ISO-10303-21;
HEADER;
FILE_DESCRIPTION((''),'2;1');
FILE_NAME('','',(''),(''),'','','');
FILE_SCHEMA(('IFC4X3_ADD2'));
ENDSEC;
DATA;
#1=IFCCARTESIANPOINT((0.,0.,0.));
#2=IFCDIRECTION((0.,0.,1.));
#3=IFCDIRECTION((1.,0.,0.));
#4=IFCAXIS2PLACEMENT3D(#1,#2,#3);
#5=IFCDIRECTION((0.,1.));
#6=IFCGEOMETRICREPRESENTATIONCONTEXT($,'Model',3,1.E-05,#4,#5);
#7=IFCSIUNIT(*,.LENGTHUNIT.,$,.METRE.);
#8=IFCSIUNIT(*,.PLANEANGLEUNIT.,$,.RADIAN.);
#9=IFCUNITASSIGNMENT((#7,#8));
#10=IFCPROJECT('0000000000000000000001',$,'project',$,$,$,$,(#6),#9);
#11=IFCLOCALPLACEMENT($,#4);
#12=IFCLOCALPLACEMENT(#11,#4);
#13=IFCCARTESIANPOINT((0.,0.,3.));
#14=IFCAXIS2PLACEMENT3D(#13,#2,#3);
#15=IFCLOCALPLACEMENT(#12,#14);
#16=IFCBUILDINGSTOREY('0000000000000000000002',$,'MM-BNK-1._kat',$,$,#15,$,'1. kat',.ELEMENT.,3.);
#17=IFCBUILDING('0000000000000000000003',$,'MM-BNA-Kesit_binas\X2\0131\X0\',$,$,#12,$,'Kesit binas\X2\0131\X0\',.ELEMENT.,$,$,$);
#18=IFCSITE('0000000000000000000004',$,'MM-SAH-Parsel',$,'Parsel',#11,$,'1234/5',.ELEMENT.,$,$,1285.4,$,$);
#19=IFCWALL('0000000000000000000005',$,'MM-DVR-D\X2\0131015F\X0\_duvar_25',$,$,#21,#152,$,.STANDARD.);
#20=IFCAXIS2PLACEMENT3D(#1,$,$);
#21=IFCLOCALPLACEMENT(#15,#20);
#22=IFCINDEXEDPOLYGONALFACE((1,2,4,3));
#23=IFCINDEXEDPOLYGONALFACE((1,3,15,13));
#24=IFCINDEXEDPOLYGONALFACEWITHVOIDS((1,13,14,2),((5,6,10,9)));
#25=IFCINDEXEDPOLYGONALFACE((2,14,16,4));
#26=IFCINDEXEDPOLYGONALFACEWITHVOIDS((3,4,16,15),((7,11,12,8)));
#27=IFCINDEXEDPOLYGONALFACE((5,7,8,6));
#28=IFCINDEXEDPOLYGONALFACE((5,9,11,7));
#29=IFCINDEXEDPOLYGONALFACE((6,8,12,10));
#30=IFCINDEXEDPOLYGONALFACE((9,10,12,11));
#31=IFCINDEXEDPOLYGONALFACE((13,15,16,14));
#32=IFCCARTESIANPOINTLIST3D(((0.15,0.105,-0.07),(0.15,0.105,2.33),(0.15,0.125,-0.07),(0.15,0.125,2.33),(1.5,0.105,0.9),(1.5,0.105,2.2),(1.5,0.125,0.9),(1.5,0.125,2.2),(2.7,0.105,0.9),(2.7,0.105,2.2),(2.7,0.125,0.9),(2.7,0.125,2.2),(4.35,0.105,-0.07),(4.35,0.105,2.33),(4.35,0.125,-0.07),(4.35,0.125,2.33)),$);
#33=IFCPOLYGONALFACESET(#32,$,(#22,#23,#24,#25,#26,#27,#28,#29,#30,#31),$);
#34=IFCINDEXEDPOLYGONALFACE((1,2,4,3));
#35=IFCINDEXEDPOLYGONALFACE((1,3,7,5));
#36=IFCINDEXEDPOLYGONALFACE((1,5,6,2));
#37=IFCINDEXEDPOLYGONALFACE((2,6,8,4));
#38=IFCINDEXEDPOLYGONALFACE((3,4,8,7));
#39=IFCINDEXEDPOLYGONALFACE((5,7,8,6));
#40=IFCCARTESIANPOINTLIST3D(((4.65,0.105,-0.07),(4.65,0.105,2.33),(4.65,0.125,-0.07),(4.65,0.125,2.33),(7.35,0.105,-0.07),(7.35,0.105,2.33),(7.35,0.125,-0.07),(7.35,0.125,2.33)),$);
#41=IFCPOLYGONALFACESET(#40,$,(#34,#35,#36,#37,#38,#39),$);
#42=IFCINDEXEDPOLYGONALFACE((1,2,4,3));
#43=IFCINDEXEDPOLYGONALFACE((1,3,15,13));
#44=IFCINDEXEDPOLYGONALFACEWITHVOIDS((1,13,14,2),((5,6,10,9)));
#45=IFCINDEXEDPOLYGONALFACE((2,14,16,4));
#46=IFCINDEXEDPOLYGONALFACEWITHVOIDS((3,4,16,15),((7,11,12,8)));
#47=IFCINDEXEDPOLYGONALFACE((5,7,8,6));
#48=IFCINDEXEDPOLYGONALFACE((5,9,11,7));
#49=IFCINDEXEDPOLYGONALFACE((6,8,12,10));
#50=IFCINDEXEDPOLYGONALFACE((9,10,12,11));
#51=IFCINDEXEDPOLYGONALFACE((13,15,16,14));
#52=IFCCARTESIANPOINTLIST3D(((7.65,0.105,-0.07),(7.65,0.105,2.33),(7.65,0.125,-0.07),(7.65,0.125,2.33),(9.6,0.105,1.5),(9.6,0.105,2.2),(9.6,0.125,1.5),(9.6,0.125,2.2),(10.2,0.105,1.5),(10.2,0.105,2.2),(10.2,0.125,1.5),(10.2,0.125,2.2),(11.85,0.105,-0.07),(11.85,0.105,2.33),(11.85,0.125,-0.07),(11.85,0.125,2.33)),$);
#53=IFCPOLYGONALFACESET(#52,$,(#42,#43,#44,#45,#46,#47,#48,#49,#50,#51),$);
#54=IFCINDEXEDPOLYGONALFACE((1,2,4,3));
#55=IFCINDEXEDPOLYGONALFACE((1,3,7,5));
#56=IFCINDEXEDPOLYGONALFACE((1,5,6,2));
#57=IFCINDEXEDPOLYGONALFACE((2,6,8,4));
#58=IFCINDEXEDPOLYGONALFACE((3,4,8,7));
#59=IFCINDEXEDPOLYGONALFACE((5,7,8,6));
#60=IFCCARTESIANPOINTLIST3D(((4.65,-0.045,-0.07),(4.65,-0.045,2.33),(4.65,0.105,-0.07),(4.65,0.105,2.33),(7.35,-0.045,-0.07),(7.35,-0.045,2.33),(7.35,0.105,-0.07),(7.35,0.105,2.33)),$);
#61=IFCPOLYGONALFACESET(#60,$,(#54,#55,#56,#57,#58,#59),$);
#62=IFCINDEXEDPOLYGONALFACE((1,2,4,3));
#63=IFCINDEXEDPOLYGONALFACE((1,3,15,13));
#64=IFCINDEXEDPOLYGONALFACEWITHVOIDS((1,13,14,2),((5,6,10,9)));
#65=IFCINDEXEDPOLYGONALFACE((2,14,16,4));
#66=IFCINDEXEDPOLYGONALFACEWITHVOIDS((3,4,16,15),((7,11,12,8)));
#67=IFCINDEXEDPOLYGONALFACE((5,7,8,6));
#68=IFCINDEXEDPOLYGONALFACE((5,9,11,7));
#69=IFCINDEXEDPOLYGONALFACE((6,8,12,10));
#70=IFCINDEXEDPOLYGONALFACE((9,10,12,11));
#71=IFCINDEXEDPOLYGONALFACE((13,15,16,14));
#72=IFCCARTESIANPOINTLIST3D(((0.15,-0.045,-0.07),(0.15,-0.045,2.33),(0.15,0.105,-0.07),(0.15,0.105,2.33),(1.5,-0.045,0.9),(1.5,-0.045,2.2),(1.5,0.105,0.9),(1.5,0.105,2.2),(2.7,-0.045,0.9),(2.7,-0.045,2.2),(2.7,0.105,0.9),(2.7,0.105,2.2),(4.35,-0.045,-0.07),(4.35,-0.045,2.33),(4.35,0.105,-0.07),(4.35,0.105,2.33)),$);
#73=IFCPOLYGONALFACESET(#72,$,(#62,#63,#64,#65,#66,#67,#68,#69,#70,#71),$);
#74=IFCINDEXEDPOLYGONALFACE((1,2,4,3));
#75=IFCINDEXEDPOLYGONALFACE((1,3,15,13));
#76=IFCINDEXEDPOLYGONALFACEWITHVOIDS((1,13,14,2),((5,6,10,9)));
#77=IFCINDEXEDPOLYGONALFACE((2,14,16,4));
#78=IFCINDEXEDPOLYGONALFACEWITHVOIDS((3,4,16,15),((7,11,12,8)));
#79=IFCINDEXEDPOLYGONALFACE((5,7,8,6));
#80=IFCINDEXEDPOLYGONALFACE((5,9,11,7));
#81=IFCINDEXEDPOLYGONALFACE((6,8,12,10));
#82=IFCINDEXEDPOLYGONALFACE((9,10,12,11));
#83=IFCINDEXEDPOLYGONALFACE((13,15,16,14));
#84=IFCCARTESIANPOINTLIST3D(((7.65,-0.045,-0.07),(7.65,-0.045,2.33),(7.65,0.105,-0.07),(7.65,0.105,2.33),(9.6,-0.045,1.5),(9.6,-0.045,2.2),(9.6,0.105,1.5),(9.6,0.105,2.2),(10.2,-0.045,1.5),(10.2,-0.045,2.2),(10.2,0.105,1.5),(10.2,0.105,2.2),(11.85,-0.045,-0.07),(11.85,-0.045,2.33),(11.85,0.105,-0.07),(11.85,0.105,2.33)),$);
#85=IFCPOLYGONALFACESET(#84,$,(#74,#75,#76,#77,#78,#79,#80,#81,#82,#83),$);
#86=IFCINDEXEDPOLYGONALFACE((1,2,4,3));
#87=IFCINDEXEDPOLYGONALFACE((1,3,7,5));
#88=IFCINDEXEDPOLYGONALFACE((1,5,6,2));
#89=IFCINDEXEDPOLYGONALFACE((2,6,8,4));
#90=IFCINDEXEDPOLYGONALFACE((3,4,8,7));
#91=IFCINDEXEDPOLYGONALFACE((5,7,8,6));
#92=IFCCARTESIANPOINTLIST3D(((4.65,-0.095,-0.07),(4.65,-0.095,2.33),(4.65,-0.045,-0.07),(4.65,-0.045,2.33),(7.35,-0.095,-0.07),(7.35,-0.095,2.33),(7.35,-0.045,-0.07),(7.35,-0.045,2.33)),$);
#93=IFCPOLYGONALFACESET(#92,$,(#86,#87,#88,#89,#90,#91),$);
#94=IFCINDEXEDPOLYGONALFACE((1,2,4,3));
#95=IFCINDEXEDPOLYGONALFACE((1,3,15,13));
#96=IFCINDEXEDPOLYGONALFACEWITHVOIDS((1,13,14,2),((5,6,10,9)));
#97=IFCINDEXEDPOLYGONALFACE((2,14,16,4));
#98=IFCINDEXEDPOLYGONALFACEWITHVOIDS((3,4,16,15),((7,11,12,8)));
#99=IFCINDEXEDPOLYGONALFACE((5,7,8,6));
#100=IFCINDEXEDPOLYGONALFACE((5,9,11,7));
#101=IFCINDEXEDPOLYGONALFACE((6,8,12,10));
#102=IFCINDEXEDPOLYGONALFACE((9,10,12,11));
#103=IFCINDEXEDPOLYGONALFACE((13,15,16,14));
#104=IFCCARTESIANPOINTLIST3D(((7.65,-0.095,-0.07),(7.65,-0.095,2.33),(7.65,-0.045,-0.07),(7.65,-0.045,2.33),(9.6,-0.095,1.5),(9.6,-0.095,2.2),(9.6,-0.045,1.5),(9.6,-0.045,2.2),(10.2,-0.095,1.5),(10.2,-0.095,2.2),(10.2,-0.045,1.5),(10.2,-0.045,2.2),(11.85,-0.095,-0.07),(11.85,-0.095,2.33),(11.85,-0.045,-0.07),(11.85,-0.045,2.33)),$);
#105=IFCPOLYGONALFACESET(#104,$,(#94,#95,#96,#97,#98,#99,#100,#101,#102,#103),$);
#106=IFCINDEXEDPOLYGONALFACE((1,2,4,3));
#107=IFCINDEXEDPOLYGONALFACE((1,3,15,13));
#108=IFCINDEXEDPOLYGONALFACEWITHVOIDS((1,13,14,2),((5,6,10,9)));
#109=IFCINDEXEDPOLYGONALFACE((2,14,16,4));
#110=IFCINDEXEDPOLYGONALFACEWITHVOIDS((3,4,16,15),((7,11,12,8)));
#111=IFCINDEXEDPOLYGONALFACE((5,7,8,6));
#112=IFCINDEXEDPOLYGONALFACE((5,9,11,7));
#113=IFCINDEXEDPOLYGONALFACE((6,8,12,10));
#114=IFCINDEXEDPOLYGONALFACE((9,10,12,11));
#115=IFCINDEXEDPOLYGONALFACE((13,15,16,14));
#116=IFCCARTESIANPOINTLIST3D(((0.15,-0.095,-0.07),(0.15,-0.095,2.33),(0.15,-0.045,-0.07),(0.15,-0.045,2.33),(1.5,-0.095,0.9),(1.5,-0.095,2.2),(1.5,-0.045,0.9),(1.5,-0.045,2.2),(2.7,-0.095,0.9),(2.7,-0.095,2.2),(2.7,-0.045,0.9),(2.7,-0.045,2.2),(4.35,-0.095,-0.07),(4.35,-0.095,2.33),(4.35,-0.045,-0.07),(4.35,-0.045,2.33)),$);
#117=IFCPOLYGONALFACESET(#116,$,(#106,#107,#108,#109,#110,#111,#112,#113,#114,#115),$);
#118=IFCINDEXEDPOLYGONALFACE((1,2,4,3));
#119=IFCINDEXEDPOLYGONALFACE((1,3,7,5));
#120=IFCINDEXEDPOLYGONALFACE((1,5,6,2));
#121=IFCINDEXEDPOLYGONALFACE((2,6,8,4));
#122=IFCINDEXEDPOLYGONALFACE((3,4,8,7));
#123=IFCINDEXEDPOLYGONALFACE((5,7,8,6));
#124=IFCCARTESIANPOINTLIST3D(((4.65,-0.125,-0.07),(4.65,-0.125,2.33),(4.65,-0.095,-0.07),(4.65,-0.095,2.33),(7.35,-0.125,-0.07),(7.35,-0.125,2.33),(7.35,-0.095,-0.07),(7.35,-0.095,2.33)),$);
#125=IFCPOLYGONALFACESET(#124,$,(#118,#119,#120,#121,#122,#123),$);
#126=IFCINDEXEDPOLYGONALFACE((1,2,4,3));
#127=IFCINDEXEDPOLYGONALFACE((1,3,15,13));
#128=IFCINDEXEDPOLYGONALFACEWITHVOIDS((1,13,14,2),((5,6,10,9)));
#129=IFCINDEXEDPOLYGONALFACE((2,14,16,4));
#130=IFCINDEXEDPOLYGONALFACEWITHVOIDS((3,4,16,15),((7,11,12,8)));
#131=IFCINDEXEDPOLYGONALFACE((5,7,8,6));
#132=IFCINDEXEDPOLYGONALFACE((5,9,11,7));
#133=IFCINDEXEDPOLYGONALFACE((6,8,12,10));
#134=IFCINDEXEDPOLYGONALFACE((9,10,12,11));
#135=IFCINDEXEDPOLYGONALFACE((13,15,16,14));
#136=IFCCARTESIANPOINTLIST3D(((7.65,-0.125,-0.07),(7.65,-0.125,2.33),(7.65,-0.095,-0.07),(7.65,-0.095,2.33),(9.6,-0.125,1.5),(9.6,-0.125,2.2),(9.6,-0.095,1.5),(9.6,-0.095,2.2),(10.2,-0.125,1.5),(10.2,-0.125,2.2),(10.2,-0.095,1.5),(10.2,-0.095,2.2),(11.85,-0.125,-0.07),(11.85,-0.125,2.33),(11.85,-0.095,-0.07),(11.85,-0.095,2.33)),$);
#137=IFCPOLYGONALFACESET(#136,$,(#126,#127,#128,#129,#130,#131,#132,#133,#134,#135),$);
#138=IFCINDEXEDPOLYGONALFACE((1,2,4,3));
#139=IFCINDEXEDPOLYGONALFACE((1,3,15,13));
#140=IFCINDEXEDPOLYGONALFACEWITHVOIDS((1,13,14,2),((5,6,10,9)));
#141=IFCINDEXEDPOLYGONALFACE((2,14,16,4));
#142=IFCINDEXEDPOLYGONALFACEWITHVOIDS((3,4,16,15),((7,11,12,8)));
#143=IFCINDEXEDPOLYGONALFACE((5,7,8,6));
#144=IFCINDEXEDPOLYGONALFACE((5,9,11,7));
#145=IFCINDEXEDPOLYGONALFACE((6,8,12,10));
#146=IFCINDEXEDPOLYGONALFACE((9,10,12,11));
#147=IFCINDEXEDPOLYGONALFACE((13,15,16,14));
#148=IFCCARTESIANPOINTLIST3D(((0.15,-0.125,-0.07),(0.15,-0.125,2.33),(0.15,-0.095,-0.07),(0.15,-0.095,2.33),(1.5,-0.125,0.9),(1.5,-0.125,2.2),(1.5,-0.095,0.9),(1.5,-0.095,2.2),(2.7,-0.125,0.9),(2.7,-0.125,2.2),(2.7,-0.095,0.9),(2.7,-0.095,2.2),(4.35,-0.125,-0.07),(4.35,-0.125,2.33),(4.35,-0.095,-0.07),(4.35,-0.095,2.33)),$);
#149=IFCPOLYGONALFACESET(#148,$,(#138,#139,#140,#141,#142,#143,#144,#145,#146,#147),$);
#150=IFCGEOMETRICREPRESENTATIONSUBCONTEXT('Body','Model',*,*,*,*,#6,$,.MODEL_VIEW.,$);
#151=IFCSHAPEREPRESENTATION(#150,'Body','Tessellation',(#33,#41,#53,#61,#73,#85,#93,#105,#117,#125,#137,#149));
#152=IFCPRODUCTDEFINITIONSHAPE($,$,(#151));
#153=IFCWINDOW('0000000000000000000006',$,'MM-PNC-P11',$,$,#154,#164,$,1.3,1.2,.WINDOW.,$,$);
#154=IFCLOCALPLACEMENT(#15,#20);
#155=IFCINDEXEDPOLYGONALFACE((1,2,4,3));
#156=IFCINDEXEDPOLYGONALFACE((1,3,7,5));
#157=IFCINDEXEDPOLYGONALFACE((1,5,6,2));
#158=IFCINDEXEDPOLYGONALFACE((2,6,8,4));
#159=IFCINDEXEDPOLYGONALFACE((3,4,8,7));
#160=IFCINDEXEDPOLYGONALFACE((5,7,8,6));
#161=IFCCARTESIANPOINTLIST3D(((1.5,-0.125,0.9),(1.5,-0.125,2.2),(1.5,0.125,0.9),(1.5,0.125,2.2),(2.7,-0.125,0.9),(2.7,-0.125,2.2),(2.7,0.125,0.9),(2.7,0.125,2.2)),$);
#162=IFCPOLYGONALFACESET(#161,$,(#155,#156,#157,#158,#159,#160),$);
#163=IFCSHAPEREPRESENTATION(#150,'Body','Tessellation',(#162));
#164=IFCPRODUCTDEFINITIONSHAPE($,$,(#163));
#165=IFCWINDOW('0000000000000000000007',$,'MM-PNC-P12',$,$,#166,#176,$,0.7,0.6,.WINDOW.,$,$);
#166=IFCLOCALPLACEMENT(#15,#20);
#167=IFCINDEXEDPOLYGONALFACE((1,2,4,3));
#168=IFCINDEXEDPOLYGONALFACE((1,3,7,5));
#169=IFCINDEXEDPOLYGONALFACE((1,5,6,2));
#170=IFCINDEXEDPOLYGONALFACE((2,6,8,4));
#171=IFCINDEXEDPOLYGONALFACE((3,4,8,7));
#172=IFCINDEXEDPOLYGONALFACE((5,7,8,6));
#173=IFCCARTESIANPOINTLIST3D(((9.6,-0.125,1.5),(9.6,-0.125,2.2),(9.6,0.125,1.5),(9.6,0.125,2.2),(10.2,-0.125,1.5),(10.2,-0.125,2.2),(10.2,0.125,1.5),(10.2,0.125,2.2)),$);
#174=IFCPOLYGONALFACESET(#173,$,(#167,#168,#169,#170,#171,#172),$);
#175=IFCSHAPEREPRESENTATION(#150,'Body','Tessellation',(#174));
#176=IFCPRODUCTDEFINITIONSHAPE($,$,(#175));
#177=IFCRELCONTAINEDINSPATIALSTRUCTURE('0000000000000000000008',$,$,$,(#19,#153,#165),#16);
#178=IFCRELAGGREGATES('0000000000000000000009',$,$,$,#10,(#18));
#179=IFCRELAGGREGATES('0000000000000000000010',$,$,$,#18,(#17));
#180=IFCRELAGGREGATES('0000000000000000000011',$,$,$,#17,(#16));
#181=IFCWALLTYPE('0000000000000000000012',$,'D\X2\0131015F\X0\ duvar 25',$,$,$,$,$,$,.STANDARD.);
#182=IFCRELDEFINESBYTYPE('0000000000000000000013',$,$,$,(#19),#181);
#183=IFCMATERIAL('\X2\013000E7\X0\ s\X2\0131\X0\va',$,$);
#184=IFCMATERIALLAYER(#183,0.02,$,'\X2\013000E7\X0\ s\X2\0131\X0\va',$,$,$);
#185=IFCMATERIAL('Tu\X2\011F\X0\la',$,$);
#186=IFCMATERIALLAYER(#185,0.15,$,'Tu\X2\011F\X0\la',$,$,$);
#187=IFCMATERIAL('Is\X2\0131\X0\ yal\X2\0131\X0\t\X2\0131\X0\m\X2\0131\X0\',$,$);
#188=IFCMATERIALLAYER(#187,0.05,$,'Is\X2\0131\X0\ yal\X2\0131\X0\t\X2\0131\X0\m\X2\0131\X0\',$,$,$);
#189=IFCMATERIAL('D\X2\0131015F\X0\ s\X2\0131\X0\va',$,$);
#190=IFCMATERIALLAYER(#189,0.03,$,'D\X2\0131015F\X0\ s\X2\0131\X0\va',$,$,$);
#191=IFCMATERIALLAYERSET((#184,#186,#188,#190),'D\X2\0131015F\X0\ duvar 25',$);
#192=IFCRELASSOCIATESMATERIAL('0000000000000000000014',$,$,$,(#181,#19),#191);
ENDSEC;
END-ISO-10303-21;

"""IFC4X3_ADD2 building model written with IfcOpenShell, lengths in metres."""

from ifc_helpers import new_model, si_unit, direction, frame, origin_with_axes, place, context, subcontext, project, spatial, polyline, outline, extrude, material, layer, layer_set, type_object, element, fill, save


model = new_model("IFC4X3_ADD2")

# Units and contexts
model_context = context("Model", 3, precision=1e-05, world=origin_with_axes(), true_north=direction((0.0, 1.0)))
body_context = subcontext(model_context, "Body", "Model", "MODEL_VIEW")
ifc_project = project(units=[si_unit("LENGTHUNIT", "METRE"), si_unit("PLANEANGLEUNIT", "RADIAN")], contexts=[model_context])

# Site, building, storey
site_placement = place(None, origin_with_axes())
site = spatial("IfcSite", under=ifc_project, at=site_placement, Name="MM-SAH-Parsel", ObjectType="Parsel", LongName="1234/5", CompositionType="ELEMENT", RefElevation=1285.4)
building_placement = place(site_placement, origin_with_axes())
building = spatial("IfcBuilding", under=site, at=building_placement, Name="MM-BNA-Kesit_binası", LongName="Kesit binası", CompositionType="ELEMENT")
storey_placement = place(building_placement, frame((0.0, 0.0, 3.0), z_axis=(0.0, 0.0, 1.0), x_axis=(1.0, 0.0, 0.0)))
storey = spatial("IfcBuildingStorey", under=building, at=storey_placement, Name="MM-BNK-1._kat", LongName="1. kat", CompositionType="ELEMENT", Elevation=3.0)

# Wall, openings, windows
ifc_material_1 = material(Name="İç sıva")
ifc_layer_1 = layer(ifc_material_1, 0.02, Name="İç sıva")
ifc_material_2 = material(Name="Tuğla")
ifc_layer_2 = layer(ifc_material_2, 0.15, Name="Tuğla")
ifc_material_3 = material(Name="Isı yalıtımı")
ifc_layer_3 = layer(ifc_material_3, 0.05, Name="Isı yalıtımı")
ifc_material_4 = material(Name="Dış sıva")
ifc_layer_4 = layer(ifc_material_4, 0.03, Name="Dış sıva")
ifc_layer_set_1 = layer_set([ifc_layer_1, ifc_layer_2, ifc_layer_3, ifc_layer_4], Name="Dış duvar 25")
wall_type_1 = type_object("IfcWallType", Name="Dış duvar 25", PredefinedType="STANDARD", material=ifc_layer_set_1)
wall_1_placement = place(storey_placement, origin_with_axes())
wall_1 = element("IfcWall", 1, at=wall_1_placement, inside=storey, type_object=wall_type_1, material=ifc_layer_set_1, Name="MM-DVR-Dış_duvar_25", PredefinedType="STANDARD", context=body_context, shape_type="SweptSolid", body=[
    extrude(outline(polyline([(0.15, 0.105), (4.35, 0.105), (4.35, 0.125), (0.15, 0.125), (0.15, 0.105)])), frame((0.0, 0.0, -0.07)), (0.0, 0.0, 1.0), 2.4),
    extrude(outline(polyline([(4.65, 0.105), (7.35, 0.105), (7.35, 0.125), (4.65, 0.125), (4.65, 0.105)])), frame((0.0, 0.0, -0.07)), (0.0, 0.0, 1.0), 2.4),
    extrude(outline(polyline([(7.65, 0.105), (11.85, 0.105), (11.85, 0.125), (7.65, 0.125), (7.65, 0.105)])), frame((0.0, 0.0, -0.07)), (0.0, 0.0, 1.0), 2.4),
    extrude(outline(polyline([(4.65, -0.045), (7.35, -0.045), (7.35, 0.105), (4.65, 0.105), (4.65, -0.045)])), frame((0.0, 0.0, -0.07)), (0.0, 0.0, 1.0), 2.4),
    extrude(outline(polyline([(0.15, -0.045), (4.35, -0.045), (4.35, 0.105), (0.15, 0.105), (0.15, -0.045)])), frame((0.0, 0.0, -0.07)), (0.0, 0.0, 1.0), 2.4),
    extrude(outline(polyline([(7.65, -0.045), (11.85, -0.045), (11.85, 0.105), (7.65, 0.105), (7.65, -0.045)])), frame((0.0, 0.0, -0.07)), (0.0, 0.0, 1.0), 2.4),
    extrude(outline(polyline([(4.65, -0.095), (7.35, -0.095), (7.35, -0.045), (4.65, -0.045), (4.65, -0.095)])), frame((0.0, 0.0, -0.07)), (0.0, 0.0, 1.0), 2.4),
    extrude(outline(polyline([(7.65, -0.095), (11.85, -0.095), (11.85, -0.045), (7.65, -0.045), (7.65, -0.095)])), frame((0.0, 0.0, -0.07)), (0.0, 0.0, 1.0), 2.4),
    extrude(outline(polyline([(0.15, -0.095), (4.35, -0.095), (4.35, -0.045), (0.15, -0.045), (0.15, -0.095)])), frame((0.0, 0.0, -0.07)), (0.0, 0.0, 1.0), 2.4),
    extrude(outline(polyline([(4.65, -0.125), (7.35, -0.125), (7.35, -0.095), (4.65, -0.095), (4.65, -0.125)])), frame((0.0, 0.0, -0.07)), (0.0, 0.0, 1.0), 2.4),
    extrude(outline(polyline([(7.65, -0.125), (11.85, -0.125), (11.85, -0.095), (7.65, -0.095), (7.65, -0.125)])), frame((0.0, 0.0, -0.07)), (0.0, 0.0, 1.0), 2.4),
    extrude(outline(polyline([(0.15, -0.125), (4.35, -0.125), (4.35, -0.095), (0.15, -0.095), (0.15, -0.125)])), frame((0.0, 0.0, -0.07)), (0.0, 0.0, 1.0), 2.4),
])
opening_1_placement = place(storey_placement, origin_with_axes())
opening_1 = element("IfcOpeningElement", 2, at=opening_1_placement, cuts=wall_1, PredefinedType="OPENING", context=body_context, shape_type="SweptSolid", body=[
    extrude(outline(polyline([(1.5, 0.125), (2.7, 0.125), (2.7, -0.125), (1.5, -0.125), (1.5, 0.125)])), frame((0.0, 0.0, 0.9)), (0.0, 0.0, 1.0), 1.3),
])
opening_2_placement = place(storey_placement, origin_with_axes())
opening_2 = element("IfcOpeningElement", 3, at=opening_2_placement, cuts=wall_1, PredefinedType="OPENING", context=body_context, shape_type="SweptSolid", body=[
    extrude(outline(polyline([(9.6, 0.125), (10.2, 0.125), (10.2, -0.125), (9.6, -0.125), (9.6, 0.125)])), frame((0.0, 0.0, 1.5)), (0.0, 0.0, 1.0), 0.7),
])
window_1_placement = place(storey_placement, origin_with_axes())
window_1 = element("IfcWindow", 4, at=window_1_placement, inside=storey, Name="MM-PNC-P11", OverallHeight=1.3, OverallWidth=1.2, PredefinedType="WINDOW", context=body_context, shape_type="SweptSolid", body=[
    extrude(outline(polyline([(1.5, 0.125), (2.7, 0.125), (2.7, -0.125), (1.5, -0.125), (1.5, 0.125)])), frame((0.0, 0.0, 0.9)), (0.0, 0.0, 1.0), 1.3),
])
fill(opening_1, window_1)
window_2_placement = place(storey_placement, origin_with_axes())
window_2 = element("IfcWindow", 5, at=window_2_placement, inside=storey, Name="MM-PNC-P12", OverallHeight=0.7, OverallWidth=0.6, PredefinedType="WINDOW", context=body_context, shape_type="SweptSolid", body=[
    extrude(outline(polyline([(9.6, 0.125), (10.2, 0.125), (10.2, -0.125), (9.6, -0.125), (9.6, 0.125)])), frame((0.0, 0.0, 1.5)), (0.0, 0.0, 1.0), 0.7),
])
fill(opening_2, window_2)

save(model, "model.ifc")
